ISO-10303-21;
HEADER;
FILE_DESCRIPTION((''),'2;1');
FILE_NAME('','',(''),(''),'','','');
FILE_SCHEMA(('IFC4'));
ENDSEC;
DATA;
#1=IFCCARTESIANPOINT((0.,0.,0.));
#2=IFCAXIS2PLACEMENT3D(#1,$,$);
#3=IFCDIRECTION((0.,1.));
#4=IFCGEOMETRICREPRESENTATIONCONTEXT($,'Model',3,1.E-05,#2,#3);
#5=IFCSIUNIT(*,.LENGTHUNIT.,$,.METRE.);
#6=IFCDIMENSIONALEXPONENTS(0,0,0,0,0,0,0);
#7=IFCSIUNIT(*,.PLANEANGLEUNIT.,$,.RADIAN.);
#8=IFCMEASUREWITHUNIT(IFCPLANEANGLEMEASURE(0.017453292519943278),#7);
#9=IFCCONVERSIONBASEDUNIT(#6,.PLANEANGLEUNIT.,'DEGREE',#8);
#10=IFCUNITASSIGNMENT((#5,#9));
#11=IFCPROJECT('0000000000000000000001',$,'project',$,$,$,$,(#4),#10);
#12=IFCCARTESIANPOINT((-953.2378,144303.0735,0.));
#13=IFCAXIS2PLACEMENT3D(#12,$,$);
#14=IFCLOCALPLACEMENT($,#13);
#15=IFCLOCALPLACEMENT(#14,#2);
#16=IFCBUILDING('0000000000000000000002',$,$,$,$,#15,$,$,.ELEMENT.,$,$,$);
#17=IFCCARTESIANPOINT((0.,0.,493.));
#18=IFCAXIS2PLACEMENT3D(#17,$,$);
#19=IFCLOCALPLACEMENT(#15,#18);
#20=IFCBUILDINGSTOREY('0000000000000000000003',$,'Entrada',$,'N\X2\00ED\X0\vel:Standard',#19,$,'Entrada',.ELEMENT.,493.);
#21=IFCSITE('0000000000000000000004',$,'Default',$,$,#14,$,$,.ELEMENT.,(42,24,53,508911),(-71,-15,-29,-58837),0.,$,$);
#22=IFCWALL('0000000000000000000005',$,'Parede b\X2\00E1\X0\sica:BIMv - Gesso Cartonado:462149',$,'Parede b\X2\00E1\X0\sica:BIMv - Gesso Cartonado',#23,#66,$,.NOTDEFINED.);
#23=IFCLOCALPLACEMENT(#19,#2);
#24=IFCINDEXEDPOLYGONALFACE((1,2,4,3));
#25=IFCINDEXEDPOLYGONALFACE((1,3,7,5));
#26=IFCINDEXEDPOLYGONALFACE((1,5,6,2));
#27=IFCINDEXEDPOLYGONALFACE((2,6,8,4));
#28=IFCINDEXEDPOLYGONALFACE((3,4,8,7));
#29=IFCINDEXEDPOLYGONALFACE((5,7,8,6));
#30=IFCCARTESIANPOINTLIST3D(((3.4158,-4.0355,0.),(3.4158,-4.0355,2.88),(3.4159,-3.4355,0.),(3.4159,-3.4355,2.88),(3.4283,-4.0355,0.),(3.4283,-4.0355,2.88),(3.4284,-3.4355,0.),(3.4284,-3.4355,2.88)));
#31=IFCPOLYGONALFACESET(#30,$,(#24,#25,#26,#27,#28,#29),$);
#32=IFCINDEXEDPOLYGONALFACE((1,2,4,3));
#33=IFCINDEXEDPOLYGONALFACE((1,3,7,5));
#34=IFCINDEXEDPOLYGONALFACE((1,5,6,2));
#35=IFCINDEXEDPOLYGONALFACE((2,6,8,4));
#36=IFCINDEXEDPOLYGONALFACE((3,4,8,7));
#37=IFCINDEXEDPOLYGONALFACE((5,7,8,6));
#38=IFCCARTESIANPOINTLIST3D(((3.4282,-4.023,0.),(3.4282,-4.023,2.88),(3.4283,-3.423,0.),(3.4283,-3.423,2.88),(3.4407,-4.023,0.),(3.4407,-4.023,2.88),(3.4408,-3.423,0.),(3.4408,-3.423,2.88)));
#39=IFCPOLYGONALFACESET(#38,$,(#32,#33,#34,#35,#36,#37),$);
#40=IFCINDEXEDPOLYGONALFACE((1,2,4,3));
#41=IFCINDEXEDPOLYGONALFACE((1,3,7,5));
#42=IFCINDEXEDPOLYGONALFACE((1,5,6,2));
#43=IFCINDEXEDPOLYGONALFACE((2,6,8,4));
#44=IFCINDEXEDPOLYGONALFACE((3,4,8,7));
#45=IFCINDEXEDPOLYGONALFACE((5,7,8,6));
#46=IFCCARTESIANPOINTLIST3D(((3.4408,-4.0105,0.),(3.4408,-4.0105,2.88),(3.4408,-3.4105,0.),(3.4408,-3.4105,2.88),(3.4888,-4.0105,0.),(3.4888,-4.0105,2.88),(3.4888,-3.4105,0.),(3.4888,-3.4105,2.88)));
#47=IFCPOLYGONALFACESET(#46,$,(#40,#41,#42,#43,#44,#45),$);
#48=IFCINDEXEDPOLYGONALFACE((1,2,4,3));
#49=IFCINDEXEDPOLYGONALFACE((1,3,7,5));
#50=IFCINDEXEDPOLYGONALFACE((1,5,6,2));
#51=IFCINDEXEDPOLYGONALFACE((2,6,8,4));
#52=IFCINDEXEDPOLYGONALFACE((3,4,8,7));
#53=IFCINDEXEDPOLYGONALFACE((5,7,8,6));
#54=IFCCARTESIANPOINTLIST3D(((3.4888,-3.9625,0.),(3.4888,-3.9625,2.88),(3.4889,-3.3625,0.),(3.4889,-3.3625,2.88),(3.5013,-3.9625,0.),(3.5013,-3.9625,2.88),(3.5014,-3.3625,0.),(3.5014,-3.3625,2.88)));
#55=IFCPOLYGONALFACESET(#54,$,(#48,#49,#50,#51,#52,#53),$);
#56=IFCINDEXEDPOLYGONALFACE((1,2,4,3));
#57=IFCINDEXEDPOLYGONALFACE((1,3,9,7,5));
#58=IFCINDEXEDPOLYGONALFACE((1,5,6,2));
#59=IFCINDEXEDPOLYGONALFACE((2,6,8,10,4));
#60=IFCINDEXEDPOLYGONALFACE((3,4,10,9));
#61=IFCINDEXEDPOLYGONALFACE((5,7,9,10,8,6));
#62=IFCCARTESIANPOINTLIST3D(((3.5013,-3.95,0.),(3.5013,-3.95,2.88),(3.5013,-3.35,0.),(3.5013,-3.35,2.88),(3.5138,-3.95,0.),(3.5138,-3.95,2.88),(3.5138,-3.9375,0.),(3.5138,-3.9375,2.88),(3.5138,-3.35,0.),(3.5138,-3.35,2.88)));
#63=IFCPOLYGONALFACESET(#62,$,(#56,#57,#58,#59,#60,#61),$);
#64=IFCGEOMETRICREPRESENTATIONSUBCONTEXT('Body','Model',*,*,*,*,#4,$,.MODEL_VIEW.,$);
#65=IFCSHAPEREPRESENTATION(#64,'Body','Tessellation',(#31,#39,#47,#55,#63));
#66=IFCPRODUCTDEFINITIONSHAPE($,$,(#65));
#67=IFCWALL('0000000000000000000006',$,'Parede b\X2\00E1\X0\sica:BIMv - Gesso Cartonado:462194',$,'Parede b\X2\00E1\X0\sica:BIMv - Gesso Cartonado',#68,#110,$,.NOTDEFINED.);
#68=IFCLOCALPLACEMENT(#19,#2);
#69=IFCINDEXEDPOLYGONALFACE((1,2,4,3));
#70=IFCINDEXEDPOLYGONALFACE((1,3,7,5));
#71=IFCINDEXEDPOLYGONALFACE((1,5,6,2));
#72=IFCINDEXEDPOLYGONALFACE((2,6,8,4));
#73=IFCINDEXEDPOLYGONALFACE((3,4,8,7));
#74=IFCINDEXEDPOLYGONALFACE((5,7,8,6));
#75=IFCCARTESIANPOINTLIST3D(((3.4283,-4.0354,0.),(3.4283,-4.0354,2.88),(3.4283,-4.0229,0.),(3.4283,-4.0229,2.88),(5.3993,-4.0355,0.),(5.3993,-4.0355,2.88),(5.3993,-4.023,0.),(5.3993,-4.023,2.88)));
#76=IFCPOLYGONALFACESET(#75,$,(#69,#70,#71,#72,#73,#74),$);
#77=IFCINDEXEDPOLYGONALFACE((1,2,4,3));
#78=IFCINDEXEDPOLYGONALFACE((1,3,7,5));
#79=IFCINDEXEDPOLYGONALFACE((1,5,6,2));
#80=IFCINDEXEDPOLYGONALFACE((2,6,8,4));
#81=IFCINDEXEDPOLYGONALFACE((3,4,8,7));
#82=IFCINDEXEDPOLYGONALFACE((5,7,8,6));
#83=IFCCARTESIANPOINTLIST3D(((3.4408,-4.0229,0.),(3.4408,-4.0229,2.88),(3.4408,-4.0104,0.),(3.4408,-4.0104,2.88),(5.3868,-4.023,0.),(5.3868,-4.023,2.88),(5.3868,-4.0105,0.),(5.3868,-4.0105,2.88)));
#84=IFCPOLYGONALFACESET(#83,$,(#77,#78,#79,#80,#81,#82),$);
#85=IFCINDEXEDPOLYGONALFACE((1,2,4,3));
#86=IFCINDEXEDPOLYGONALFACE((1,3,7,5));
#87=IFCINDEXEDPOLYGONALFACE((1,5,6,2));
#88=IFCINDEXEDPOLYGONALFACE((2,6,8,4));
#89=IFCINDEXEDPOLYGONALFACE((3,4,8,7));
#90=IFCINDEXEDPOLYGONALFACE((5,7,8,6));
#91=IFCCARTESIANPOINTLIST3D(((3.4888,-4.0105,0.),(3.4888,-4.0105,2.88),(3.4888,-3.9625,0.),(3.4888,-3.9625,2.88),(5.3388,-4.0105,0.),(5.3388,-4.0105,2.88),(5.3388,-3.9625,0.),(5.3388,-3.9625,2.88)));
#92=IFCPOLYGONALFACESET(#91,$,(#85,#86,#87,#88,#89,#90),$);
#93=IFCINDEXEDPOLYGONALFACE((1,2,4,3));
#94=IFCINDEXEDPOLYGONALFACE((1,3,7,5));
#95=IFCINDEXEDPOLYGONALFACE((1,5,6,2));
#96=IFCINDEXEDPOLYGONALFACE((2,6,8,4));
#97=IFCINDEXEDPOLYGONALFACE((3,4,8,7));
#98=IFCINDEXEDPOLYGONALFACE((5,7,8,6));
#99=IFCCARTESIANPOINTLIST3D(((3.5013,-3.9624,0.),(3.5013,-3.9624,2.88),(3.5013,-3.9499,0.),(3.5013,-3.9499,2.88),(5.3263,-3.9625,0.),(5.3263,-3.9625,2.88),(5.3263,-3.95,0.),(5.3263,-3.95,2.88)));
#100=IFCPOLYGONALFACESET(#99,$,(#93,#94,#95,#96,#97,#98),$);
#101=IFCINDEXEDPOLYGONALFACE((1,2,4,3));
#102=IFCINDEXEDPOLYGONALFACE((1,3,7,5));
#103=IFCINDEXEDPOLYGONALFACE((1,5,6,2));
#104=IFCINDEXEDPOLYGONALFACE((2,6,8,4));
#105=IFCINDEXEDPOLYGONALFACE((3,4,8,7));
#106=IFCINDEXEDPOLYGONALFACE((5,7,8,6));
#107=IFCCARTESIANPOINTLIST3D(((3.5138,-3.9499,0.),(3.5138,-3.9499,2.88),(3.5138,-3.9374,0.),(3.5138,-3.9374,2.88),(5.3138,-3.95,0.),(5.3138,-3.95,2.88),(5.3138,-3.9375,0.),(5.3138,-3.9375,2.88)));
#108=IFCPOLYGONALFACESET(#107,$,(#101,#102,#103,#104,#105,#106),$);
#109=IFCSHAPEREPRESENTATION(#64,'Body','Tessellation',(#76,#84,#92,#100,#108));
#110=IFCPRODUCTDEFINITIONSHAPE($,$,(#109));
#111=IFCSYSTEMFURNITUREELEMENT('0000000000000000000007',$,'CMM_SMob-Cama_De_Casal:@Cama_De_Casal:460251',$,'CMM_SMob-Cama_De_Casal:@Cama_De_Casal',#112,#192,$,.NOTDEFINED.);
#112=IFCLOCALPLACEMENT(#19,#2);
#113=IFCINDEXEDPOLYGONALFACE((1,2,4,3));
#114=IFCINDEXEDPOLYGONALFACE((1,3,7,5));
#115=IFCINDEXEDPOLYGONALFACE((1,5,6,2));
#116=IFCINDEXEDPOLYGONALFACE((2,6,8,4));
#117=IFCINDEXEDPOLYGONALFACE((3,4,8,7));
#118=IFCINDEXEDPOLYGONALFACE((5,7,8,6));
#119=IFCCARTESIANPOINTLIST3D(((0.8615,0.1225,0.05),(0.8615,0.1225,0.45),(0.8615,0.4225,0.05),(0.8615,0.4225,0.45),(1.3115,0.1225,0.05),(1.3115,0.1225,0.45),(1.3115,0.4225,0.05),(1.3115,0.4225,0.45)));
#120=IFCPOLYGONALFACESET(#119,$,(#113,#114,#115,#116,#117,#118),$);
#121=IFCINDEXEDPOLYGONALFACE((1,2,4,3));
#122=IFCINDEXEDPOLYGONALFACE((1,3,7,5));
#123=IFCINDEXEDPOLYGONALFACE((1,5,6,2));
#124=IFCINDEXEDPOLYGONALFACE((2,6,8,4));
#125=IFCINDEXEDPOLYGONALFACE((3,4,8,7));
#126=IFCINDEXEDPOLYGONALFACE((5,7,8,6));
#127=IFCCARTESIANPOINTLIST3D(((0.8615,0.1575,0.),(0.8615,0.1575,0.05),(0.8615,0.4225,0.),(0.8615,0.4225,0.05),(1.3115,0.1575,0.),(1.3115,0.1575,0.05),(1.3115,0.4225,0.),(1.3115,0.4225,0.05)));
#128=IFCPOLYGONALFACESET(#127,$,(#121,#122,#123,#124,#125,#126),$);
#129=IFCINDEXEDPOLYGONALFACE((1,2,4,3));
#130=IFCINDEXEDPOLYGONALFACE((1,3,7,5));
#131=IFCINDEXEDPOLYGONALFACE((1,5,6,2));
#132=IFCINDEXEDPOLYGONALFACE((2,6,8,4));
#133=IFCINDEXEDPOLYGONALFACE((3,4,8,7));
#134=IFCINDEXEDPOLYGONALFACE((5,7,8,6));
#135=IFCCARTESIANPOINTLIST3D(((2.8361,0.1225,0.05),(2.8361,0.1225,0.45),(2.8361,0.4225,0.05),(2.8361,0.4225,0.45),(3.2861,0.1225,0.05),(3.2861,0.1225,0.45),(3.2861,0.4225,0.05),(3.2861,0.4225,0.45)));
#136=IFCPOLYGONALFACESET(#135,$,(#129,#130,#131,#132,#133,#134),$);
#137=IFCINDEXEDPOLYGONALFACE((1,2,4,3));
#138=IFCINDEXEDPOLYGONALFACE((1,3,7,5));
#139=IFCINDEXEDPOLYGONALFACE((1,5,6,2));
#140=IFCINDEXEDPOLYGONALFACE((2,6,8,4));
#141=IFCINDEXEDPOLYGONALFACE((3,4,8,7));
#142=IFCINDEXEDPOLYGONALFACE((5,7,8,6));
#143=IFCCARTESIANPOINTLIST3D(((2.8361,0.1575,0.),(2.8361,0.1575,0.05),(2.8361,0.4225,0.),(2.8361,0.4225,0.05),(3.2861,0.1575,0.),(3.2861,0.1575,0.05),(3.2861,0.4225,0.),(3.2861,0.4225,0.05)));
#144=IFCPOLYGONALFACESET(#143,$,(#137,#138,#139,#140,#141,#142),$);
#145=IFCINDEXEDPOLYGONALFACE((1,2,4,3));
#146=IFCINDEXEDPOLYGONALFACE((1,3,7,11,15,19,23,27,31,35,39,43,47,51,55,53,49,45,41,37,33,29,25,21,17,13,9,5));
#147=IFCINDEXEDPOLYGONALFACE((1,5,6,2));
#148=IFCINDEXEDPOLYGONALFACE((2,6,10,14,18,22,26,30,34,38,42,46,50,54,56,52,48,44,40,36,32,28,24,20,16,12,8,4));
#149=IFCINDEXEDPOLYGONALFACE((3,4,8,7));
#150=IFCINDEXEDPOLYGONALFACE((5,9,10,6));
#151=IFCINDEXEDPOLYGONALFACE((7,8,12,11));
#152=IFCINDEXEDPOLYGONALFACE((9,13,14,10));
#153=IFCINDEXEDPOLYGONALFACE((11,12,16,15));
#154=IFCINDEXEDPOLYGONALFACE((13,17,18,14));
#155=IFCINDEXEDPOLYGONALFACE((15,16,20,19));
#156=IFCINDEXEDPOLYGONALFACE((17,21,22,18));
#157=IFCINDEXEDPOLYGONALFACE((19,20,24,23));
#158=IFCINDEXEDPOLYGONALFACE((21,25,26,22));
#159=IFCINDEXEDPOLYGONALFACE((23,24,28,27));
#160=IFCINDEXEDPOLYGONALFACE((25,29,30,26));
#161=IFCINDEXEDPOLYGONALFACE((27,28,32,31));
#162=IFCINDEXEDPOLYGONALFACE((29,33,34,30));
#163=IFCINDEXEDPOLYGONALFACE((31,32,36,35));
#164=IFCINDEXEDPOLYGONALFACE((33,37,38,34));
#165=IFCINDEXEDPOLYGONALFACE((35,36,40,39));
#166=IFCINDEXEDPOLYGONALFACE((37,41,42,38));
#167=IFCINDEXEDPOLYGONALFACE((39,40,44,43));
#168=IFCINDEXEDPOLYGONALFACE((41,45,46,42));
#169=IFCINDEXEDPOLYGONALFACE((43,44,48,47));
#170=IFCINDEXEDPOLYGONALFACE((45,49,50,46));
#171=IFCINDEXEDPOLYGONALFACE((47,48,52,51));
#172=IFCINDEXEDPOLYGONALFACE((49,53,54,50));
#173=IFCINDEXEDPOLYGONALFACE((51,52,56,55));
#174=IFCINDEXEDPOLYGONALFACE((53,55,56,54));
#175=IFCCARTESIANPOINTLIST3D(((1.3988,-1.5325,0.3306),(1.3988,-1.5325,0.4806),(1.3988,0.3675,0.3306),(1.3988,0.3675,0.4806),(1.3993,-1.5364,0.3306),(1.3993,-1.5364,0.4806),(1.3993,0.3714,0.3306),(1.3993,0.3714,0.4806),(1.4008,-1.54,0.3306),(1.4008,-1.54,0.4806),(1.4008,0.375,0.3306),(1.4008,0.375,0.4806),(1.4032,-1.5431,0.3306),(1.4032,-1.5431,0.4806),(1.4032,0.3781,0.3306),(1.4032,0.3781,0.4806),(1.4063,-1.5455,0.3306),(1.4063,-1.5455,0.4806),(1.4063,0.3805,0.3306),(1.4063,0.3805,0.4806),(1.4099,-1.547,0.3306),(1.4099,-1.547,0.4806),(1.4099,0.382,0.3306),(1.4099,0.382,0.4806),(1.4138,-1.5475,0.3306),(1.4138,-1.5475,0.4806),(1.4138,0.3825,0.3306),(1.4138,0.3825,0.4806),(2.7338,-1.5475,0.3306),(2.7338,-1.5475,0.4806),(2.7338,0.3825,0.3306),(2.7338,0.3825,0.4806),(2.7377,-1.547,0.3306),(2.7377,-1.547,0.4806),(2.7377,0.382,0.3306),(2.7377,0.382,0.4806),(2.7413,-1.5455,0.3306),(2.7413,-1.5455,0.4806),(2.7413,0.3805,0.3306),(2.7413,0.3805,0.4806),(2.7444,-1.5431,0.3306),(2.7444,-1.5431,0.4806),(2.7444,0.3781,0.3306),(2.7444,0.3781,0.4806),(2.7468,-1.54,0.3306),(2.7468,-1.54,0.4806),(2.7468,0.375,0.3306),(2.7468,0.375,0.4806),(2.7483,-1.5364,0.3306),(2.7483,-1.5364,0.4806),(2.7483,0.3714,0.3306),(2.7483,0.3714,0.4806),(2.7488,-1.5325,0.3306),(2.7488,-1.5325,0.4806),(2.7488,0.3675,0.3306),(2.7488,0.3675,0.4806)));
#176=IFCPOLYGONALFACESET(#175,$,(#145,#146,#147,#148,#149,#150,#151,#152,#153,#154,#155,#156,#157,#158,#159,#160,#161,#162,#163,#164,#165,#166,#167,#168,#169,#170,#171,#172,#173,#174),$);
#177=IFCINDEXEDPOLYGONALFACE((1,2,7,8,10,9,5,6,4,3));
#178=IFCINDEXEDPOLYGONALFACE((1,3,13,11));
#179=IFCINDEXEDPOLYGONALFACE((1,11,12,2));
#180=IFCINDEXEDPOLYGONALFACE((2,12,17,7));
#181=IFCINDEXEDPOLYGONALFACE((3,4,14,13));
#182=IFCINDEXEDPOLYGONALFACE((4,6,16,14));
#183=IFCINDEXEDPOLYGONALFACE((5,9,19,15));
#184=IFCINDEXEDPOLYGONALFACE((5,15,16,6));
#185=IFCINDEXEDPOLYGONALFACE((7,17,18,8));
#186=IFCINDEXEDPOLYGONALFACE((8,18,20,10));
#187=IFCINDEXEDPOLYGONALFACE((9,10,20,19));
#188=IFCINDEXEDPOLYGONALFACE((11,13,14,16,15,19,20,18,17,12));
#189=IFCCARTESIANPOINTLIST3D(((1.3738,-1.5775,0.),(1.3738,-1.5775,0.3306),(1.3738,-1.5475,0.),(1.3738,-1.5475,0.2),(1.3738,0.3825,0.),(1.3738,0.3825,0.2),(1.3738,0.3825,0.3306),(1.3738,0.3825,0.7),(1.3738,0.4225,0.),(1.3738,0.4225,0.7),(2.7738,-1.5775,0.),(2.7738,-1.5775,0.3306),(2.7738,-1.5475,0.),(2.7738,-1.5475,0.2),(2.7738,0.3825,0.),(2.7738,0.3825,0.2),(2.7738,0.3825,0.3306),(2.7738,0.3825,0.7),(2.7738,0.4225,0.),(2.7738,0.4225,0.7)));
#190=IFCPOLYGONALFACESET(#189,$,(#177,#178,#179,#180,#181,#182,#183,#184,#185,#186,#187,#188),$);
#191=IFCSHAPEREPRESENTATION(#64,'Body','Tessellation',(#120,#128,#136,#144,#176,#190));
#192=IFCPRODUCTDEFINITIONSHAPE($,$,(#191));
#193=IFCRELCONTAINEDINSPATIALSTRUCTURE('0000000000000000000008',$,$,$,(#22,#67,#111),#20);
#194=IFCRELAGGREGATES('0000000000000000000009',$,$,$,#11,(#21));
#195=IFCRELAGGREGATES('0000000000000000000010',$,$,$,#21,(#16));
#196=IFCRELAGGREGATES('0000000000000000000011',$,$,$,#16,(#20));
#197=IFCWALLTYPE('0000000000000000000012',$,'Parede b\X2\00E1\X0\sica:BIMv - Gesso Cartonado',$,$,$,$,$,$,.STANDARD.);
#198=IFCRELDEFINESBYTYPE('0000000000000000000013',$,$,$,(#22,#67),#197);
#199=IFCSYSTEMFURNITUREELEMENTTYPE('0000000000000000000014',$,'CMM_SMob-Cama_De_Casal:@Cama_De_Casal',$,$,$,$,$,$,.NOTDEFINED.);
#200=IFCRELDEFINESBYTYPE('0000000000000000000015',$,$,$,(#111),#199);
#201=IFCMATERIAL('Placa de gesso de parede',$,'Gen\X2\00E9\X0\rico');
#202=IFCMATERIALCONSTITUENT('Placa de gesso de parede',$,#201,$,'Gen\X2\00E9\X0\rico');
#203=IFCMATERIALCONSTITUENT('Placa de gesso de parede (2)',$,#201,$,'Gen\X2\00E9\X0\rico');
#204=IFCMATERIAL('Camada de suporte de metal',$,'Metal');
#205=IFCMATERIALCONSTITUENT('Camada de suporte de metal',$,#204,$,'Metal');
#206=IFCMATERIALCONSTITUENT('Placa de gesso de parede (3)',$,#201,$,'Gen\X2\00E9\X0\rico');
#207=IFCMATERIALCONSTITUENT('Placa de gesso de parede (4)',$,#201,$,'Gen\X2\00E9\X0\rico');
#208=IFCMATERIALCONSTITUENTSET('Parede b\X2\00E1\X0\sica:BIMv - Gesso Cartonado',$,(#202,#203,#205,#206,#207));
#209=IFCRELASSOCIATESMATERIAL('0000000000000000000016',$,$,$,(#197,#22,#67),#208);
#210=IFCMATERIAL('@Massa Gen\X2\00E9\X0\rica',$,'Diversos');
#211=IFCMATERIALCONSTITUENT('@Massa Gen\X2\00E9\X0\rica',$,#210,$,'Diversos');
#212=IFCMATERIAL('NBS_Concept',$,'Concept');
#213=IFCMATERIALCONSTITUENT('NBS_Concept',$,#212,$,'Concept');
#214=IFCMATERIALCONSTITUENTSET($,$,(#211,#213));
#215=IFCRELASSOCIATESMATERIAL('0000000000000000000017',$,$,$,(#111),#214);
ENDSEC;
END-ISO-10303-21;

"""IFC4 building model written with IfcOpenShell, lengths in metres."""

from ifc_helpers import new_model, entity, si_unit, converted_unit, direction, frame, origin, place, context, subcontext, project, spatial, line, arc, indexed_curve, outline, extrude, source, transform, mapped, material, constituent, constituent_set, type_object, type_shapes, element, save


model = new_model("IFC4")

# Units and contexts
model_context = context("Model", 3, precision=1e-05, world=origin(), true_north=direction((0.0, 1.0)))
body_context = subcontext(model_context, "Body", "Model", "MODEL_VIEW")
ifc_project = project(units=[si_unit("LENGTHUNIT", "METRE"), converted_unit("PLANEANGLEUNIT", "DEGREE", entity("IfcPlaneAngleMeasure", 0.017453292519943278), si_unit("PLANEANGLEUNIT", "RADIAN"), dimensions=[0, 0, 0, 0, 0, 0, 0])], contexts=[model_context])

# Site, building, storey
site_placement = place(None, frame((-953.2378, 144303.0735, 0.0)))
site = spatial("IfcSite", under=ifc_project, at=site_placement, Name="Default", CompositionType="ELEMENT", RefLatitude=(42, 24, 53, 508911), RefLongitude=(-71, -15, -29, -58837), RefElevation=0.0)
building_placement = place(site_placement, origin())
building = spatial("IfcBuilding", under=site, at=building_placement, CompositionType="ELEMENT")
storey_placement = place(building_placement, frame((0.0, 0.0, 493.0)))
storey = spatial("IfcBuildingStorey", under=building, at=storey_placement, Name="Entrada", ObjectType="Nível:Standard", LongName="Entrada", CompositionType="ELEMENT", Elevation=493.0)

# Walls
ifc_material_1 = material(Name="Placa de gesso de parede", Category="Genérico")
ifc_constituent_1 = constituent(ifc_material_1, Name="Placa de gesso de parede", Category="Genérico")
ifc_constituent_2 = constituent(ifc_material_1, Name="Placa de gesso de parede (2)", Category="Genérico")
ifc_material_2 = material(Name="Camada de suporte de metal", Category="Metal")
ifc_constituent_3 = constituent(ifc_material_2, Name="Camada de suporte de metal", Category="Metal")
ifc_constituent_4 = constituent(ifc_material_1, Name="Placa de gesso de parede (3)", Category="Genérico")
ifc_constituent_5 = constituent(ifc_material_1, Name="Placa de gesso de parede (4)", Category="Genérico")
ifc_constituent_set_1 = constituent_set(constituents=[ifc_constituent_1, ifc_constituent_2, ifc_constituent_3, ifc_constituent_4, ifc_constituent_5], Name="Parede básica:BIMv - Gesso Cartonado")
wall_type = type_object("IfcWallType", Name="Parede básica:BIMv - Gesso Cartonado", PredefinedType="STANDARD", material=ifc_constituent_set_1)
wall_1_placement = place(storey_placement, frame((3.4648, -3.4355, 0.0), z_axis=(0.0, 0.0, 1.0), x_axis=(0.0, -1.0, 0.0)))
element("IfcWall", 1, at=wall_1_placement, inside=storey, type_object=wall_type, material=ifc_constituent_set_1, Name="Parede básica:BIMv - Gesso Cartonado:462149", ObjectType="Parede básica:BIMv - Gesso Cartonado", PredefinedType="NOTDEFINED", context=body_context, shape_type="SweptSolid", body=[
    extrude(outline(indexed_curve([(-0.0063, -0.3), (0.0062, -0.3), (0.0063, 0.3), (-0.0062, 0.3), (-0.0063, -0.3)], self_intersect=False)), frame((0.3, -0.0427, 0.0), z_axis=(0.0, 0.0, 1.0), x_axis=(0.0, 1.0, 0.0)), (0.0, 0.0, 1.0), 2.88),
    extrude(outline(indexed_curve([(-0.3, -0.0062), (0.3, -0.0063), (0.3, 0.0062), (-0.3, 0.0063), (-0.3, -0.0062)], self_intersect=False)), frame((0.2875, -0.0303, 0.0)), (0.0, 0.0, 1.0), 2.88),
    extrude(outline(indexed_curve([(-0.3, -0.024), (0.3, -0.024), (0.3, 0.024), (-0.3, 0.024), (-0.3, -0.024)], self_intersect=False)), frame((0.275, 0.0, 0.0)), (0.0, 0.0, 1.0), 2.88),
    extrude(outline(indexed_curve([(-0.3, -0.0062), (0.3, -0.0063), (0.3, 0.0062), (-0.3, 0.0063), (-0.3, -0.0062)], self_intersect=False)), frame((0.227, 0.0303, 0.0)), (0.0, 0.0, 1.0), 2.88),
    extrude(outline(indexed_curve([(-0.23, -0.005), (0.3575, -0.005), (0.3575, 0.0075), (-0.2425, 0.0075), (-0.2425, -0.005), (-0.23, -0.005)], self_intersect=False)), frame((0.272, 0.044, 0.0), z_axis=(0.0, 0.0, 1.0), x_axis=(-1.0, 0.0, 0.0)), (0.0, 0.0, 1.0), 2.88),
])
wall_2_placement = place(storey_placement, frame((3.5138, -3.9865, 0.0)))
element("IfcWall", 2, at=wall_2_placement, inside=storey, type_object=wall_type, material=ifc_constituent_set_1, Name="Parede básica:BIMv - Gesso Cartonado:462194", ObjectType="Parede básica:BIMv - Gesso Cartonado", PredefinedType="NOTDEFINED", context=body_context, shape_type="SweptSolid", body=[
    extrude(outline(indexed_curve([(-0.0063, -0.9855), (0.0062, -0.9855), (0.0063, 0.9855), (-0.0062, 0.9855), (-0.0063, -0.9855)], self_intersect=False)), frame((0.9, -0.0427, 0.0), z_axis=(0.0, 0.0, 1.0), x_axis=(0.0, 1.0, 0.0)), (0.0, 0.0, 1.0), 2.88),
    extrude(outline(indexed_curve([(-0.973, -0.0062), (0.973, -0.0063), (0.973, 0.0062), (-0.973, 0.0063), (-0.973, -0.0062)], self_intersect=False)), frame((0.9, -0.0302, 0.0)), (0.0, 0.0, 1.0), 2.88),
    extrude(outline(indexed_curve([(-0.925, -0.024), (0.925, -0.024), (0.925, 0.024), (-0.925, 0.024), (-0.925, -0.024)], self_intersect=False)), frame((0.9, 0.0, 0.0)), (0.0, 0.0, 1.0), 2.88),
    extrude(outline(indexed_curve([(-0.9125, -0.0062), (0.9125, -0.0063), (0.9125, 0.0062), (-0.9125, 0.0063), (-0.9125, -0.0062)], self_intersect=False)), frame((0.9, 0.0303, 0.0)), (0.0, 0.0, 1.0), 2.88),
    extrude(outline(indexed_curve([(-0.0063, -0.9), (0.0062, -0.9), (0.0063, 0.9), (-0.0062, 0.9), (-0.0063, -0.9)], self_intersect=False)), frame((0.9, 0.0428, 0.0), z_axis=(0.0, 0.0, 1.0), x_axis=(0.0, -1.0, 0.0)), (0.0, 0.0, 1.0), 2.88),
])

# System furniture element
ifc_material_3 = material(Name="@Massa Genérica", Category="Diversos")
ifc_constituent_6 = constituent(ifc_material_3, Name="@Massa Genérica", Category="Diversos")
ifc_material_4 = material(Name="NBS_Concept", Category="Concept")
ifc_constituent_7 = constituent(ifc_material_4, Name="NBS_Concept", Category="Concept")
ifc_constituent_set_2 = constituent_set(constituents=[ifc_constituent_6, ifc_constituent_7])
system_furniture_element_type = type_object("IfcSystemFurnitureElementType", Name="CMM_SMob-Cama_De_Casal:@Cama_De_Casal", PredefinedType="NOTDEFINED")
shared_shape = source(origin(), body_context, "Body", "SweptSolid", [
    extrude(outline(indexed_curve([(-0.15, -0.225), (0.15, -0.225), (0.15, 0.225), (-0.15, 0.225), (-0.15, -0.225)], self_intersect=False)), frame((-0.9873, -0.15, 0.05), z_axis=(0.0, 0.0, 1.0), x_axis=(0.0, 1.0, 0.0)), (0.0, 0.0, 1.0), 0.4),
    extrude(outline(indexed_curve([(-0.1325, -0.225), (0.1325, -0.225), (0.1325, 0.225), (-0.1325, 0.225), (-0.1325, -0.225)], self_intersect=False)), frame((-0.9873, -0.1325, 0.0), z_axis=(0.0, 0.0, 1.0), x_axis=(0.0, -1.0, 0.0)), (0.0, 0.0, 1.0), 0.05),
    extrude(outline(indexed_curve([(-0.225, -0.15), (0.225, -0.15), (0.225, 0.15), (-0.225, 0.15), (-0.225, -0.15)], self_intersect=False)), frame((0.9873, -0.15, 0.05)), (0.0, 0.0, 1.0), 0.4),
    extrude(outline(indexed_curve([(-0.225, -0.1325), (0.225, -0.1325), (0.225, 0.1325), (-0.225, 0.1325), (-0.225, -0.1325)], self_intersect=False)), frame((0.9873, -0.1325, 0.0), z_axis=(0.0, 0.0, 1.0), x_axis=(-1.0, 0.0, 0.0)), (0.0, 0.0, 1.0), 0.05),
    extrude(outline(indexed_curve([(-0.66, -0.965), (0.66, -0.965), (0.6706, -0.9606), (0.675, -0.95), (0.675, 0.95), (0.6706, 0.9606), (0.66, 0.965), (-0.66, 0.965), (-0.6706, 0.9606), (-0.675, 0.95), (-0.675, -0.95), (-0.6706, -0.9606)], segments=[line(1, 2), arc(2, 3, 4), line(4, 5), arc(5, 6, 7), line(7, 8), arc(8, 9, 10), line(10, 11), arc(11, 12, 1)], self_intersect=False)), frame((0.0, -1.005, 0.3306), z_axis=(0.0, 0.0, 1.0), x_axis=(-1.0, 0.0, 0.0)), (0.0, 0.0, 1.0), 0.15),
    extrude(outline(indexed_curve([(-0.2461, -1.16), (-0.2461, -1.19), (0.0845, -1.19), (0.0845, 0.77), (0.4539, 0.77), (0.4539, 0.81), (-0.2461, 0.81), (-0.2461, 0.77), (-0.0461, 0.77), (-0.0461, -1.16), (-0.2461, -1.16)], self_intersect=False)), frame((-0.7, -0.81, 0.2461), z_axis=(-1.0, 0.0, 0.0), x_axis=(0.0, 0.0, 1.0)), (0.0, 0.0, -1.0), 1.4),
])
type_shapes(system_furniture_element_type, [shared_shape])
system_furniture_element_placement = place(storey_placement, frame((2.0738, 0.4225, 0.0)))
element("IfcSystemFurnitureElement", 3, at=system_furniture_element_placement, inside=storey, type_object=system_furniture_element_type, material=ifc_constituent_set_2, Name="CMM_SMob-Cama_De_Casal:@Cama_De_Casal:460251", ObjectType="CMM_SMob-Cama_De_Casal:@Cama_De_Casal", PredefinedType="NOTDEFINED", context=body_context, shape_type="MappedRepresentation", body=[
    mapped(shared_shape, transform((0.0, 0.0, 0.0), scale=1.0)),
])

save(model, "model.ifc")
